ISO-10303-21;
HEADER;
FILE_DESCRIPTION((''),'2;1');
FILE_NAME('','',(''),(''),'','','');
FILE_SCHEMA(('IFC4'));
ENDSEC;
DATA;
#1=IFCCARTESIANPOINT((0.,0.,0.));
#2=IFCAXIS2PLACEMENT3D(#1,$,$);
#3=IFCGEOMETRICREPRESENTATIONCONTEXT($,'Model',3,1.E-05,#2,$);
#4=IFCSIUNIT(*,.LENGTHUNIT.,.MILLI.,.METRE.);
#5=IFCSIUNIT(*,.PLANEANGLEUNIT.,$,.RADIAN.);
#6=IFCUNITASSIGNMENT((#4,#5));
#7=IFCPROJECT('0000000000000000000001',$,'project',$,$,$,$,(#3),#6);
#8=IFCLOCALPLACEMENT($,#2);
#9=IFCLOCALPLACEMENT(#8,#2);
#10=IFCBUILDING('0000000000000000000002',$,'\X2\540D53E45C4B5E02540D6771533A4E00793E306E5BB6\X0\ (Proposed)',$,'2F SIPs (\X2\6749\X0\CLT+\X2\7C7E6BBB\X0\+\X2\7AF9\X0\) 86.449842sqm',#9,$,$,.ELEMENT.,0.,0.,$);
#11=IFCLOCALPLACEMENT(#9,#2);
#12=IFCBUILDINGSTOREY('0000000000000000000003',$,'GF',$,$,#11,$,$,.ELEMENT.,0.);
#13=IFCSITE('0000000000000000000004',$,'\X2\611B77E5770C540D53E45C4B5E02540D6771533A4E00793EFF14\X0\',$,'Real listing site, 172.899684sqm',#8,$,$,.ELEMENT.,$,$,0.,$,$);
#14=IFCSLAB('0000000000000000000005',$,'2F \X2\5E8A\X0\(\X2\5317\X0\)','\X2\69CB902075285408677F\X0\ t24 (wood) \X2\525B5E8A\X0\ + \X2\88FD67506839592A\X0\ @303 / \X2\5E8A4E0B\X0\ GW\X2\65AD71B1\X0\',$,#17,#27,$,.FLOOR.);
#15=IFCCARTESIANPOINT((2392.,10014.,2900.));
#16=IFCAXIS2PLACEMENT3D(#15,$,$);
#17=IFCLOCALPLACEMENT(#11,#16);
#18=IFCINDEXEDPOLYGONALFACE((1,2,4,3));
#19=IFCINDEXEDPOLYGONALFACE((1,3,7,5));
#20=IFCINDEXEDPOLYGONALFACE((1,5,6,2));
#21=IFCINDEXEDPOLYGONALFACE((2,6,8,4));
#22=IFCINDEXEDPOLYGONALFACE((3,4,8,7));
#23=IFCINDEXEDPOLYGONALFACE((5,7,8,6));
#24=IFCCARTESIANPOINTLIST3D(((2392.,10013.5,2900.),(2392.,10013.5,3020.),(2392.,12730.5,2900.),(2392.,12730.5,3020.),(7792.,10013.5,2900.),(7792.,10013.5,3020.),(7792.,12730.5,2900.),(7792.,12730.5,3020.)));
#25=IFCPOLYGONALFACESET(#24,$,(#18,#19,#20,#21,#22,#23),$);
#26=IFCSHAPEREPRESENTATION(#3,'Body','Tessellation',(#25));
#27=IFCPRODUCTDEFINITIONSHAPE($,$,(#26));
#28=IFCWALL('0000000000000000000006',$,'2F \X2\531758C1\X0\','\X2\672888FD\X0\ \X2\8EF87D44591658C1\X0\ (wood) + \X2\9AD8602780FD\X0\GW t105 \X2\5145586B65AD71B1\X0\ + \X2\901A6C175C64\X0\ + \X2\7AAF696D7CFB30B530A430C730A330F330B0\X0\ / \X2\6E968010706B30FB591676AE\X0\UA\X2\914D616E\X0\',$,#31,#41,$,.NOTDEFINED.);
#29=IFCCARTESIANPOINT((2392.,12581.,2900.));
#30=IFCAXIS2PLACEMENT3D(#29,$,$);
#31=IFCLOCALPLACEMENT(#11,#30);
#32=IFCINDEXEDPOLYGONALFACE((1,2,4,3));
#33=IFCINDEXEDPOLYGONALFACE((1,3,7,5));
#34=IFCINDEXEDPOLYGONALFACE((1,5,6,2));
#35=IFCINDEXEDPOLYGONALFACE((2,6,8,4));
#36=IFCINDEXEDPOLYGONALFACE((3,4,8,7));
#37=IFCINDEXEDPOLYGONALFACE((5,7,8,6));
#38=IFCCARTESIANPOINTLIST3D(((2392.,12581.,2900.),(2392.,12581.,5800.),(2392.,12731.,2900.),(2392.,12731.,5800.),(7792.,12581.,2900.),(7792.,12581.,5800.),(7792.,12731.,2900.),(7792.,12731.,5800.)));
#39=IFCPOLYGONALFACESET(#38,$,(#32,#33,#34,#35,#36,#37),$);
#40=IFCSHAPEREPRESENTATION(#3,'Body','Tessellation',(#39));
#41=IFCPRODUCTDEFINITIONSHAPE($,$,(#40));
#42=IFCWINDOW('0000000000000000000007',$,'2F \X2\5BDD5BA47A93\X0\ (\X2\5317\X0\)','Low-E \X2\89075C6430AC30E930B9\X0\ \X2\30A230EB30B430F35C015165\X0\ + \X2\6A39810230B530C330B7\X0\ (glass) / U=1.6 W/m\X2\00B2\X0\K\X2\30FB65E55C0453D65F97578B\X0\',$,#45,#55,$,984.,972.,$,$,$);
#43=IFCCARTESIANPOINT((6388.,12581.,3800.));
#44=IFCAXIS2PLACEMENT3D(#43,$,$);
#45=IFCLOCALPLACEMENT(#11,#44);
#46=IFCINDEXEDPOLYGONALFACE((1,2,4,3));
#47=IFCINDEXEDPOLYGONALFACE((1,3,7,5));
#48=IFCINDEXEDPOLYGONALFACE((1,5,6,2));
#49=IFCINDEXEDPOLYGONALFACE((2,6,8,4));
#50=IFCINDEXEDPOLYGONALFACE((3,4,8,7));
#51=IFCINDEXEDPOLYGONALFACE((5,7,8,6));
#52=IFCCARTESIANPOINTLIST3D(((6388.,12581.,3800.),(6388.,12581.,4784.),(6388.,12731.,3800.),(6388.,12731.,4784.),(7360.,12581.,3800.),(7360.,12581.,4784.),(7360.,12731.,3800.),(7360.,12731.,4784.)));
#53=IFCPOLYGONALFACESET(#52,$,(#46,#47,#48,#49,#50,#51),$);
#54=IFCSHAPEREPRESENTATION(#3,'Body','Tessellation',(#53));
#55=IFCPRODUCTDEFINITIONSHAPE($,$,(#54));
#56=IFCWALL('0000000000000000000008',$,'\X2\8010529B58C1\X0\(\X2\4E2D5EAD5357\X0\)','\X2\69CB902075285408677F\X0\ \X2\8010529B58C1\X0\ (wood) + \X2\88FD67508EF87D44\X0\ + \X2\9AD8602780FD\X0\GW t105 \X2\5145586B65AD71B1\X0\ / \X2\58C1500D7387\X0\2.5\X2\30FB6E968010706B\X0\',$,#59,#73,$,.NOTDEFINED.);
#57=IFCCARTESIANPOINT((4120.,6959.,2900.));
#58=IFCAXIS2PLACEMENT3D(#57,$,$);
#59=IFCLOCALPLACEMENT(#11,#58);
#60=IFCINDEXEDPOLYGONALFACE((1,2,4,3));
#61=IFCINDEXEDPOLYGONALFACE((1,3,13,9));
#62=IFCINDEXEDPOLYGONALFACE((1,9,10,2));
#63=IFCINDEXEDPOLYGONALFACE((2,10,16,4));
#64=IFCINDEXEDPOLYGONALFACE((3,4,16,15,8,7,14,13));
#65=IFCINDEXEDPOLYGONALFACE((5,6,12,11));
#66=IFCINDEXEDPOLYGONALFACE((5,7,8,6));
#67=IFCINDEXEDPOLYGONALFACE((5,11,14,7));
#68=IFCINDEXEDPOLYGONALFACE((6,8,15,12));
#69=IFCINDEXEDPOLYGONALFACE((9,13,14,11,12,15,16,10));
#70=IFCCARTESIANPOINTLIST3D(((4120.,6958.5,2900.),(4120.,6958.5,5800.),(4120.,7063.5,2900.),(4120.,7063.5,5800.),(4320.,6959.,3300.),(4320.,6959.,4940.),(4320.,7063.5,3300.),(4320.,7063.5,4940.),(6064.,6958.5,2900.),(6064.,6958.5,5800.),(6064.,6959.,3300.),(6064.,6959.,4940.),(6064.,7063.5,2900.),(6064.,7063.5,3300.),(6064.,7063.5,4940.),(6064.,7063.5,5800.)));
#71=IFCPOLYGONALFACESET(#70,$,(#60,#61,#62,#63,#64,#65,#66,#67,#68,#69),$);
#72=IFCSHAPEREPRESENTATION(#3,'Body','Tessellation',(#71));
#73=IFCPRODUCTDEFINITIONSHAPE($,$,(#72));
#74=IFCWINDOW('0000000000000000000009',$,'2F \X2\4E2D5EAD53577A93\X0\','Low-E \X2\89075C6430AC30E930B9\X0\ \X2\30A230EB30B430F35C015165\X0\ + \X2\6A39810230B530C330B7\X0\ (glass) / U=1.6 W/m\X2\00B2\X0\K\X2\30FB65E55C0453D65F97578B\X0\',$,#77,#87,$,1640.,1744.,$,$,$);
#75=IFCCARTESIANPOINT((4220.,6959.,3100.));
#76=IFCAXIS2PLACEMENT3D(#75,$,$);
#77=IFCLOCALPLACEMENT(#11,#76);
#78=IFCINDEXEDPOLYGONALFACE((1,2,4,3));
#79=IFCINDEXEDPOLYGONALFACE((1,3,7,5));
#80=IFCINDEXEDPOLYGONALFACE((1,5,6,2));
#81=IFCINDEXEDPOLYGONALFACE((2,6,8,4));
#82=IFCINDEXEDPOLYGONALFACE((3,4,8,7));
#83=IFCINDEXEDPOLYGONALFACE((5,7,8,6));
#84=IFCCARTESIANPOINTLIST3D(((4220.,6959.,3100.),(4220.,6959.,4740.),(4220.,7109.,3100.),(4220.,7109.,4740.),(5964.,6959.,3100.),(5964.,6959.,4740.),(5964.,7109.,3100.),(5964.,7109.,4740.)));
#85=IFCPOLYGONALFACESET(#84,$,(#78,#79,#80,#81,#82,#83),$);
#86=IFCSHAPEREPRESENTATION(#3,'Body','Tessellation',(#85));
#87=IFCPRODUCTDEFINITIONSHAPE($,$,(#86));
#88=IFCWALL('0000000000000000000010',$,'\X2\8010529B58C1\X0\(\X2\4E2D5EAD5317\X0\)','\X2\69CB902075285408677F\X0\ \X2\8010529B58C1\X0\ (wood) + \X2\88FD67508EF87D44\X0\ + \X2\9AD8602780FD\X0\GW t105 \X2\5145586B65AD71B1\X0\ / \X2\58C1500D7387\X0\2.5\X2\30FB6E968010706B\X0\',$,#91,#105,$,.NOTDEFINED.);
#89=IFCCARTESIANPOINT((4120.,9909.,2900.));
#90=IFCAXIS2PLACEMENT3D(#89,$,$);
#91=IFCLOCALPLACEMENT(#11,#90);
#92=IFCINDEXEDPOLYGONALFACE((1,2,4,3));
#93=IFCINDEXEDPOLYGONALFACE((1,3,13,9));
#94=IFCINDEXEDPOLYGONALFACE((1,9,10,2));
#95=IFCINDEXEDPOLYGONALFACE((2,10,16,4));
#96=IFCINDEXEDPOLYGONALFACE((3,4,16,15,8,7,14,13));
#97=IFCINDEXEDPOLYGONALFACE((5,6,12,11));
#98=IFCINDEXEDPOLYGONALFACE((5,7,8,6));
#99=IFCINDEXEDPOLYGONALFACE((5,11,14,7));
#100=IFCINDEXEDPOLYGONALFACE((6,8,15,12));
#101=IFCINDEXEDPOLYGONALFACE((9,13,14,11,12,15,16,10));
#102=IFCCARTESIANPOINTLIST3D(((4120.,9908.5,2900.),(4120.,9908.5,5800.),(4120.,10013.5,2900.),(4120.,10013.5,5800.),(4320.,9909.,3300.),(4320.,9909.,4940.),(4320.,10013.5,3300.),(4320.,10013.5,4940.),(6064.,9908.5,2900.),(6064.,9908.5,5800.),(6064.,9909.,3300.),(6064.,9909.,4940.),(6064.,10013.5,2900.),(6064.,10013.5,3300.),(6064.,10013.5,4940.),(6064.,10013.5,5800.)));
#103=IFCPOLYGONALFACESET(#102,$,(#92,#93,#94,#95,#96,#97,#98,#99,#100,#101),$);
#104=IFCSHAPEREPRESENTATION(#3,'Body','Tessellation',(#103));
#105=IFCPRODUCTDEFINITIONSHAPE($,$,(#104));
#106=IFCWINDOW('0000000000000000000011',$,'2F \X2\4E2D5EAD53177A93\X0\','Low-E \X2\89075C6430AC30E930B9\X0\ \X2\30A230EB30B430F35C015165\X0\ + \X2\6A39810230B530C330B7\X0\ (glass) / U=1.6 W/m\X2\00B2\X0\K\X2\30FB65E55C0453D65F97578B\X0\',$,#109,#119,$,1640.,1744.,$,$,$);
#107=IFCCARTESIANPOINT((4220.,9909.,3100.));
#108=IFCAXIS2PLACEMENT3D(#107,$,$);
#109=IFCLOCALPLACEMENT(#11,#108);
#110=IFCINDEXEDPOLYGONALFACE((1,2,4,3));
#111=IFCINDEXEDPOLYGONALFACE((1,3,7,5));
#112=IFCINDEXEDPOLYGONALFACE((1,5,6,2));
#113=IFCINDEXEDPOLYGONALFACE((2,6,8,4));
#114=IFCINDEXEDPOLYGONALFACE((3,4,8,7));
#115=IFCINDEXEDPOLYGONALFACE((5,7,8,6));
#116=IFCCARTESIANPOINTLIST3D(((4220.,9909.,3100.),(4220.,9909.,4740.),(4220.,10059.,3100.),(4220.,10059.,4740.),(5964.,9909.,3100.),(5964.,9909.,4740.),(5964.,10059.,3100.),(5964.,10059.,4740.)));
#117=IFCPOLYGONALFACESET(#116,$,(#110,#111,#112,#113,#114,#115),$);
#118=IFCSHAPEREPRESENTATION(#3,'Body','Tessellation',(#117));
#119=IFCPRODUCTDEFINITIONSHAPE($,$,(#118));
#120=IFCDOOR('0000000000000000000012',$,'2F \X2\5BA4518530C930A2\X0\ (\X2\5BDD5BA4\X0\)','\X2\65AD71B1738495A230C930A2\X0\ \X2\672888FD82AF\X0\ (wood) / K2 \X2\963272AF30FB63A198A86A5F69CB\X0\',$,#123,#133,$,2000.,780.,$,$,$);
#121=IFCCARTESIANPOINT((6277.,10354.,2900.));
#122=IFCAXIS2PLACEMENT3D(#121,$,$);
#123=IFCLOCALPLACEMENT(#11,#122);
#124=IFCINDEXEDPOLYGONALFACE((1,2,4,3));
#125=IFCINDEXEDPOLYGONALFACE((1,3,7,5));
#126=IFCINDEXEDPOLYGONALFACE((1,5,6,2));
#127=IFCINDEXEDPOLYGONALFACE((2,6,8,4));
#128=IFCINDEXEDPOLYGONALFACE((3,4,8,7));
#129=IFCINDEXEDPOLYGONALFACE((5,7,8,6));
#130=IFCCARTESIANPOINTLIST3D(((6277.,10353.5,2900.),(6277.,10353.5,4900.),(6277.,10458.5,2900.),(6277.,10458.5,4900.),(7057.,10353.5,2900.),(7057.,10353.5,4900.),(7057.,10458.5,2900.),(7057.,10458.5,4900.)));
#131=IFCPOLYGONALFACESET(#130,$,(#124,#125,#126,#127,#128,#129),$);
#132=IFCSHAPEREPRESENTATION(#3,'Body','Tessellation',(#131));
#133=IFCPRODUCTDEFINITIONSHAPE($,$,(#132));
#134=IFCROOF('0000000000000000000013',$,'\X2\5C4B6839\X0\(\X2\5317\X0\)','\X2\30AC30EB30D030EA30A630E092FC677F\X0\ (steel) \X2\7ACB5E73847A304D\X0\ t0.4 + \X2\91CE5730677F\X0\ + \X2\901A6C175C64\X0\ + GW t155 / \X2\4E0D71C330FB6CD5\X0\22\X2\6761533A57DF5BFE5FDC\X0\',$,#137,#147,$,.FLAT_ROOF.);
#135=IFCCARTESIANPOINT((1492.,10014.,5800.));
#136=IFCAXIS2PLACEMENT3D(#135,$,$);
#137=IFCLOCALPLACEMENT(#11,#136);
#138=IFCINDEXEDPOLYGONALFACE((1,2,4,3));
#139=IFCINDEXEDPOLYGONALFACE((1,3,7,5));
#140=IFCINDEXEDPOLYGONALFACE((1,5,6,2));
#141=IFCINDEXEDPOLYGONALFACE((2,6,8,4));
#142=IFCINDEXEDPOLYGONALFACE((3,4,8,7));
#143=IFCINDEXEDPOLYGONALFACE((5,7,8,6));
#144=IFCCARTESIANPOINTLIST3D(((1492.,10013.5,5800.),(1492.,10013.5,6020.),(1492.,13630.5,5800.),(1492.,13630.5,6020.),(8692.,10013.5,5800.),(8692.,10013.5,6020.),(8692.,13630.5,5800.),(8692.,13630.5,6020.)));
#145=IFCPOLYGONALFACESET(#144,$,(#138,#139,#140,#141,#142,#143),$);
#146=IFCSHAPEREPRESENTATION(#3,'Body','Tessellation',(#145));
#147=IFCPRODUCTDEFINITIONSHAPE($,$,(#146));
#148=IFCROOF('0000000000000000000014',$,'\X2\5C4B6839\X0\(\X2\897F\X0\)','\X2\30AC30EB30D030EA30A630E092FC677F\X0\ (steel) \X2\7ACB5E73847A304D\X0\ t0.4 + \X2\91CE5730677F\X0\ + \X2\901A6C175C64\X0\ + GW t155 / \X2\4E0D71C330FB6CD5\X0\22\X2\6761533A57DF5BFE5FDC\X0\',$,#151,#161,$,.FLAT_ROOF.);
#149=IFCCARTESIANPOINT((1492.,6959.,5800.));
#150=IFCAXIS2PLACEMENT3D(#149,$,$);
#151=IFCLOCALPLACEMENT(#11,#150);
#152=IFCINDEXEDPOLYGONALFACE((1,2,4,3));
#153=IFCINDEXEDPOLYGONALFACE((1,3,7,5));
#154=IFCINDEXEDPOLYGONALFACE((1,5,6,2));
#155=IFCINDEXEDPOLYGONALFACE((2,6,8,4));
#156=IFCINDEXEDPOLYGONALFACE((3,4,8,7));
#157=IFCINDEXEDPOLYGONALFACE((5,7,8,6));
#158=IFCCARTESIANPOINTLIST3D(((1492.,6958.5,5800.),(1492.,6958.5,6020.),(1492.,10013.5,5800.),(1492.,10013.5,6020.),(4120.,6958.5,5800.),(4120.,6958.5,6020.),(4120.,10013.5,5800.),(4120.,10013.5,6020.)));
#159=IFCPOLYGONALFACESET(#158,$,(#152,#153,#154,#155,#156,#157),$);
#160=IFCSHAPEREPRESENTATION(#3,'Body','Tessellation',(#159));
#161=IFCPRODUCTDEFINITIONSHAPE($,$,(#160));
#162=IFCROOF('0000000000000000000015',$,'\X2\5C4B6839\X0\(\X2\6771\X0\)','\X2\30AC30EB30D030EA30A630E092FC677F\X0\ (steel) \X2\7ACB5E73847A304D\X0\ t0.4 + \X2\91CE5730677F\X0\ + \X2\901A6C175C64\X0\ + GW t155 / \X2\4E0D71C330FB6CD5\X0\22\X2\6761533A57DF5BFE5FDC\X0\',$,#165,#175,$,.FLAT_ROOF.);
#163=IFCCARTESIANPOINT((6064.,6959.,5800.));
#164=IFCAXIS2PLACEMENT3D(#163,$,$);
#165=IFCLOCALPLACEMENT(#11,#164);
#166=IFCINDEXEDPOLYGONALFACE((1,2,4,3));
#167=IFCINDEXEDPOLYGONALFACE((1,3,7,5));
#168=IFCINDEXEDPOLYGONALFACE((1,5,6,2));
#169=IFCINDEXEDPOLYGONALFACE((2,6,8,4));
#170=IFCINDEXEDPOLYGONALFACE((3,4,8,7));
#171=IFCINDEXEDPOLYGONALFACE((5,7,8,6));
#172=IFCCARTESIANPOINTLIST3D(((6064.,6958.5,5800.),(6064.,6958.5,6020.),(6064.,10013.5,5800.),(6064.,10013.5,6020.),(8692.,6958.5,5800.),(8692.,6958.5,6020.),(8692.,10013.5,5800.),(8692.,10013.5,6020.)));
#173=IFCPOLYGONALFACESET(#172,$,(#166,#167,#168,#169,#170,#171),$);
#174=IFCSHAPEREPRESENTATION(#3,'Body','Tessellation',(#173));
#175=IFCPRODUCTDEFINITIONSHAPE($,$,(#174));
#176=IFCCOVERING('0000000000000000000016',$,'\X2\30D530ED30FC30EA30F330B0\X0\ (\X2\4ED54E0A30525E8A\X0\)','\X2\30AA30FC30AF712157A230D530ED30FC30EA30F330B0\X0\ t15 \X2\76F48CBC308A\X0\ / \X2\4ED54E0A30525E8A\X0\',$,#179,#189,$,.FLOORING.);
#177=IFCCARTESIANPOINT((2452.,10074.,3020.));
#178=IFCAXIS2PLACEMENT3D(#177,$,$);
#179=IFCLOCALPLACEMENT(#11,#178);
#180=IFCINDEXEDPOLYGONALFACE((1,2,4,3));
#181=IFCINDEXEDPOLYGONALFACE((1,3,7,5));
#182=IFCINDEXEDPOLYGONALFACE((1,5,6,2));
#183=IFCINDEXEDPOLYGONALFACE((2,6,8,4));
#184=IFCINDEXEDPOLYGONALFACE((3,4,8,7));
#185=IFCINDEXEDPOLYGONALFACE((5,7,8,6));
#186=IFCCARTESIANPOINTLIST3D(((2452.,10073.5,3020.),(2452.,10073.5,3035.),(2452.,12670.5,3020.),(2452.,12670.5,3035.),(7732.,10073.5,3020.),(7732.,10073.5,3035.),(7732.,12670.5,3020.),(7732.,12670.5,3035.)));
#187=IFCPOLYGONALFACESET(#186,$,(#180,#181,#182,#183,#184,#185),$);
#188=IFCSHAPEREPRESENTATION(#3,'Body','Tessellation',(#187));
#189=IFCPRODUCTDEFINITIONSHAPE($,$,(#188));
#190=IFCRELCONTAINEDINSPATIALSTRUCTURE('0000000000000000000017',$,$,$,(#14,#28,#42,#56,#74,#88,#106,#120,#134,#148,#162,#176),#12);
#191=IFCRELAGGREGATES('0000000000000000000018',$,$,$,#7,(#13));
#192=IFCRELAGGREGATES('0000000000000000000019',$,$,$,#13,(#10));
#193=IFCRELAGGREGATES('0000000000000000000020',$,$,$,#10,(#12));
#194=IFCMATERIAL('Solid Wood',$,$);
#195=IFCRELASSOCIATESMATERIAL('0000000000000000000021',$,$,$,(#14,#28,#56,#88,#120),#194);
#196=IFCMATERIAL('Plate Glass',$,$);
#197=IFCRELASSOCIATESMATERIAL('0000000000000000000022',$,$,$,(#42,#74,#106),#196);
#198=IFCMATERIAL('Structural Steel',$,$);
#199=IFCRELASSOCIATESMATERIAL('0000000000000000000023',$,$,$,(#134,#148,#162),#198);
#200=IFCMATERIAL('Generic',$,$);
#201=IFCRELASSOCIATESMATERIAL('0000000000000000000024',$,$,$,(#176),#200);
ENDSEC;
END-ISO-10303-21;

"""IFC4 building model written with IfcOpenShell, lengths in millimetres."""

from ifc_helpers import new_model, si_unit, frame, frame_2d, origin, place, context, project, spatial, rectangle, extrude, material, element, fill, save


model = new_model("IFC4")

# Units and contexts
model_context = context("Model", 3, precision=1e-05, world=origin())
ifc_project = project(units=[si_unit("LENGTHUNIT", "METRE", prefix="MILLI"), si_unit("PLANEANGLEUNIT", "RADIAN")], contexts=[model_context])

# Site, building, storey
site_placement = place(None, origin())
site = spatial("IfcSite", under=ifc_project, at=site_placement, Name="愛知県名古屋市名東区一社４", ObjectType="Real listing site, 172.899684sqm", CompositionType="ELEMENT", RefElevation=0.0)
building_placement = place(site_placement, origin())
building = spatial("IfcBuilding", under=site, at=building_placement, Name="名古屋市名東区一社の家 (Proposed)", ObjectType="2F SIPs (杉CLT+籾殻+竹) 86.449842sqm", CompositionType="ELEMENT", ElevationOfRefHeight=0.0, ElevationOfTerrain=0.0)
storey_placement = place(building_placement, origin())
storey = spatial("IfcBuildingStorey", under=building, at=storey_placement, Name="GF", CompositionType="ELEMENT", Elevation=0.0)

# Slab
ifc_material_1 = material(Name="Solid Wood")
slab_placement = place(storey_placement, frame((2392.0, 10014.0, 2900.0)))
element("IfcSlab", 1, at=slab_placement, inside=storey, material=ifc_material_1, Name="2F 床(北)", Description="構造用合板 t24 (wood) 剛床 + 製材根太 @303 / 床下 GW断熱", PredefinedType="FLOOR", context=model_context, shape_type="SweptSolid", body=[
    extrude(rectangle(XDim=5400.0, YDim=2717.0, at=frame_2d((2700.0, 1358.0))), frame((2392.0, 10014.0, 2900.0)), (0.0, 0.0, 1.0), 120.0),
])

# Walls, openings, windows
wall_1_placement = place(storey_placement, frame((2392.0, 12581.0, 2900.0)))
wall_1 = element("IfcWall", 2, at=wall_1_placement, inside=storey, material=ifc_material_1, Name="2F 北壁", Description="木製 軸組外壁 (wood) + 高性能GW t105 充填断熱 + 通気層 + 窯業系サイディング / 準耐火・外皮UA配慮", PredefinedType="NOTDEFINED", context=model_context, shape_type="SweptSolid", body=[
    extrude(rectangle(XDim=5400.0, YDim=150.0, at=frame_2d((2700.0, 75.0))), frame((2392.0, 12581.0, 2900.0)), (0.0, 0.0, 1.0), 2900.0),
])
opening_1_placement = place(storey_placement, frame((6388.0, 12581.0, 3800.0)))
opening_1 = element("IfcOpeningElement", 3, at=opening_1_placement, cuts=wall_1, PredefinedType="NOTDEFINED", context=model_context, shape_type="SweptSolid", body=[
    extrude(rectangle(XDim=972.0, YDim=150.0, at=frame_2d((486.0, 75.0))), frame((6388.0, 12581.0, 3800.0)), (0.0, 0.0, 1.0), 984.0),
])
ifc_material_2 = material(Name="Plate Glass")
window_1_placement = place(storey_placement, frame((6388.0, 12581.0, 3800.0)))
window_1 = element("IfcWindow", 4, at=window_1_placement, inside=storey, material=ifc_material_2, Name="2F 寝室窓 (北)", Description="Low-E 複層ガラス アルゴン封入 + 樹脂サッシ (glass) / U=1.6 W/m²K・日射取得型", OverallHeight=984.0, OverallWidth=972.0, context=model_context, shape_type="SweptSolid", body=[
    extrude(rectangle(XDim=972.0, YDim=150.0, at=frame_2d((486.0, 75.0))), frame((6388.0, 12581.0, 3800.0)), (0.0, 0.0, 1.0), 984.0),
])
fill(opening_1, window_1)
wall_2_placement = place(storey_placement, frame((4120.0, 6959.0, 2900.0)))
wall_2 = element("IfcWall", 5, at=wall_2_placement, inside=storey, material=ifc_material_1, Name="耐力壁(中庭南)", Description="構造用合板 耐力壁 (wood) + 製材軸組 + 高性能GW t105 充填断熱 / 壁倍率2.5・準耐火", PredefinedType="NOTDEFINED", context=model_context, shape_type="SweptSolid", body=[
    extrude(rectangle(XDim=1944.0, YDim=105.0, at=frame_2d((972.0, 52.0))), frame((4120.0, 6959.0, 2900.0)), (0.0, 0.0, 1.0), 2900.0),
])
opening_2_placement = place(storey_placement, frame((4220.0, 6959.0, 3100.0)))
opening_2 = element("IfcOpeningElement", 6, at=opening_2_placement, cuts=wall_2, PredefinedType="NOTDEFINED", context=model_context, shape_type="SweptSolid", body=[
    extrude(rectangle(XDim=1744.0, YDim=150.0, at=frame_2d((872.0, 75.0))), frame((4220.0, 6959.0, 3100.0)), (0.0, 0.0, 1.0), 1640.0),
])
window_2_placement = place(storey_placement, frame((4220.0, 6959.0, 3100.0)))
window_2 = element("IfcWindow", 7, at=window_2_placement, inside=storey, material=ifc_material_2, Name="2F 中庭南窓", Description="Low-E 複層ガラス アルゴン封入 + 樹脂サッシ (glass) / U=1.6 W/m²K・日射取得型", OverallHeight=1640.0, OverallWidth=1744.0, context=model_context, shape_type="SweptSolid", body=[
    extrude(rectangle(XDim=1744.0, YDim=150.0, at=frame_2d((872.0, 75.0))), frame((4220.0, 6959.0, 3100.0)), (0.0, 0.0, 1.0), 1640.0),
])
fill(opening_2, window_2)
wall_3_placement = place(storey_placement, frame((4120.0, 9909.0, 2900.0)))
wall_3 = element("IfcWall", 8, at=wall_3_placement, inside=storey, material=ifc_material_1, Name="耐力壁(中庭北)", Description="構造用合板 耐力壁 (wood) + 製材軸組 + 高性能GW t105 充填断熱 / 壁倍率2.5・準耐火", PredefinedType="NOTDEFINED", context=model_context, shape_type="SweptSolid", body=[
    extrude(rectangle(XDim=1944.0, YDim=105.0, at=frame_2d((972.0, 52.0))), frame((4120.0, 9909.0, 2900.0)), (0.0, 0.0, 1.0), 2900.0),
])
opening_3_placement = place(storey_placement, frame((4220.0, 9909.0, 3100.0)))
opening_3 = element("IfcOpeningElement", 9, at=opening_3_placement, cuts=wall_3, PredefinedType="NOTDEFINED", context=model_context, shape_type="SweptSolid", body=[
    extrude(rectangle(XDim=1744.0, YDim=150.0, at=frame_2d((872.0, 75.0))), frame((4220.0, 9909.0, 3100.0)), (0.0, 0.0, 1.0), 1640.0),
])
window_3_placement = place(storey_placement, frame((4220.0, 9909.0, 3100.0)))
window_3 = element("IfcWindow", 10, at=window_3_placement, inside=storey, material=ifc_material_2, Name="2F 中庭北窓", Description="Low-E 複層ガラス アルゴン封入 + 樹脂サッシ (glass) / U=1.6 W/m²K・日射取得型", OverallHeight=1640.0, OverallWidth=1744.0, context=model_context, shape_type="SweptSolid", body=[
    extrude(rectangle(XDim=1744.0, YDim=150.0, at=frame_2d((872.0, 75.0))), frame((4220.0, 9909.0, 3100.0)), (0.0, 0.0, 1.0), 1640.0),
])
fill(opening_3, window_3)

# Door
door_placement = place(storey_placement, frame((6277.0, 10354.0, 2900.0)))
element("IfcDoor", 11, at=door_placement, inside=storey, material=ifc_material_1, Name="2F 室内ドア (寝室)", Description="断熱玄関ドア 木製芯 (wood) / K2 防犯・採風機構", OverallHeight=2000.0, OverallWidth=780.0, context=model_context, shape_type="SweptSolid", body=[
    extrude(rectangle(XDim=780.0, YDim=105.0, at=frame_2d((390.0, 52.0))), frame((6277.0, 10354.0, 2900.0)), (0.0, 0.0, 1.0), 2000.0),
])

# Roofs
ifc_material_3 = material(Name="Structural Steel")
for number, where, name in (
    (12, (1492.0, 10014.0, 5800.0), "屋根(北)"),
):
    element("IfcRoof", number, at=place(storey_placement, frame(where)), inside=storey, material=ifc_material_3, Name=name, Description="ガルバリウム鋼板 (steel) 立平葺き t0.4 + 野地板 + 通気層 + GW t155 / 不燃・法22条区域対応", PredefinedType="FLAT_ROOF", context=model_context, shape_type="SweptSolid", body=[
        extrude(rectangle(XDim=7200.0, YDim=3617.0, at=frame_2d((3600.0, 1808.0))), frame((1492.0, 10014.0, 5800.0)), (0.0, 0.0, 1.0), 220.0),
    ])
roof_1_placement = place(storey_placement, frame((1492.0, 6959.0, 5800.0)))
element("IfcRoof", 13, at=roof_1_placement, inside=storey, material=ifc_material_3, Name="屋根(西)", Description="ガルバリウム鋼板 (steel) 立平葺き t0.4 + 野地板 + 通気層 + GW t155 / 不燃・法22条区域対応", PredefinedType="FLAT_ROOF", context=model_context, shape_type="SweptSolid", body=[
    extrude(rectangle(XDim=2628.0, YDim=3055.0, at=frame_2d((1314.0, 1527.0))), frame((1492.0, 6959.0, 5800.0)), (0.0, 0.0, 1.0), 220.0),
])
roof_2_placement = place(storey_placement, frame((6064.0, 6959.0, 5800.0)))
element("IfcRoof", 14, at=roof_2_placement, inside=storey, material=ifc_material_3, Name="屋根(東)", Description="ガルバリウム鋼板 (steel) 立平葺き t0.4 + 野地板 + 通気層 + GW t155 / 不燃・法22条区域対応", PredefinedType="FLAT_ROOF", context=model_context, shape_type="SweptSolid", body=[
    extrude(rectangle(XDim=2628.0, YDim=3055.0, at=frame_2d((1314.0, 1527.0))), frame((6064.0, 6959.0, 5800.0)), (0.0, 0.0, 1.0), 220.0),
])

# Covering
ifc_material_4 = material(Name="Generic")
covering_1_placement = place(storey_placement, frame((2452.0, 10074.0, 3020.0)))
element("IfcCovering", 15, at=covering_1_placement, inside=storey, material=ifc_material_4, Name="フローリング (仕上げ床)", Description="オーク無垢フローリング t15 直貼り / 仕上げ床", PredefinedType="FLOORING", context=model_context, shape_type="SweptSolid", body=[
    extrude(rectangle(XDim=5280.0, YDim=2597.0, at=frame_2d((2640.0, 1298.0))), frame((2452.0, 10074.0, 3020.0)), (0.0, 0.0, 1.0), 15.0),
])

save(model, "model.ifc")
